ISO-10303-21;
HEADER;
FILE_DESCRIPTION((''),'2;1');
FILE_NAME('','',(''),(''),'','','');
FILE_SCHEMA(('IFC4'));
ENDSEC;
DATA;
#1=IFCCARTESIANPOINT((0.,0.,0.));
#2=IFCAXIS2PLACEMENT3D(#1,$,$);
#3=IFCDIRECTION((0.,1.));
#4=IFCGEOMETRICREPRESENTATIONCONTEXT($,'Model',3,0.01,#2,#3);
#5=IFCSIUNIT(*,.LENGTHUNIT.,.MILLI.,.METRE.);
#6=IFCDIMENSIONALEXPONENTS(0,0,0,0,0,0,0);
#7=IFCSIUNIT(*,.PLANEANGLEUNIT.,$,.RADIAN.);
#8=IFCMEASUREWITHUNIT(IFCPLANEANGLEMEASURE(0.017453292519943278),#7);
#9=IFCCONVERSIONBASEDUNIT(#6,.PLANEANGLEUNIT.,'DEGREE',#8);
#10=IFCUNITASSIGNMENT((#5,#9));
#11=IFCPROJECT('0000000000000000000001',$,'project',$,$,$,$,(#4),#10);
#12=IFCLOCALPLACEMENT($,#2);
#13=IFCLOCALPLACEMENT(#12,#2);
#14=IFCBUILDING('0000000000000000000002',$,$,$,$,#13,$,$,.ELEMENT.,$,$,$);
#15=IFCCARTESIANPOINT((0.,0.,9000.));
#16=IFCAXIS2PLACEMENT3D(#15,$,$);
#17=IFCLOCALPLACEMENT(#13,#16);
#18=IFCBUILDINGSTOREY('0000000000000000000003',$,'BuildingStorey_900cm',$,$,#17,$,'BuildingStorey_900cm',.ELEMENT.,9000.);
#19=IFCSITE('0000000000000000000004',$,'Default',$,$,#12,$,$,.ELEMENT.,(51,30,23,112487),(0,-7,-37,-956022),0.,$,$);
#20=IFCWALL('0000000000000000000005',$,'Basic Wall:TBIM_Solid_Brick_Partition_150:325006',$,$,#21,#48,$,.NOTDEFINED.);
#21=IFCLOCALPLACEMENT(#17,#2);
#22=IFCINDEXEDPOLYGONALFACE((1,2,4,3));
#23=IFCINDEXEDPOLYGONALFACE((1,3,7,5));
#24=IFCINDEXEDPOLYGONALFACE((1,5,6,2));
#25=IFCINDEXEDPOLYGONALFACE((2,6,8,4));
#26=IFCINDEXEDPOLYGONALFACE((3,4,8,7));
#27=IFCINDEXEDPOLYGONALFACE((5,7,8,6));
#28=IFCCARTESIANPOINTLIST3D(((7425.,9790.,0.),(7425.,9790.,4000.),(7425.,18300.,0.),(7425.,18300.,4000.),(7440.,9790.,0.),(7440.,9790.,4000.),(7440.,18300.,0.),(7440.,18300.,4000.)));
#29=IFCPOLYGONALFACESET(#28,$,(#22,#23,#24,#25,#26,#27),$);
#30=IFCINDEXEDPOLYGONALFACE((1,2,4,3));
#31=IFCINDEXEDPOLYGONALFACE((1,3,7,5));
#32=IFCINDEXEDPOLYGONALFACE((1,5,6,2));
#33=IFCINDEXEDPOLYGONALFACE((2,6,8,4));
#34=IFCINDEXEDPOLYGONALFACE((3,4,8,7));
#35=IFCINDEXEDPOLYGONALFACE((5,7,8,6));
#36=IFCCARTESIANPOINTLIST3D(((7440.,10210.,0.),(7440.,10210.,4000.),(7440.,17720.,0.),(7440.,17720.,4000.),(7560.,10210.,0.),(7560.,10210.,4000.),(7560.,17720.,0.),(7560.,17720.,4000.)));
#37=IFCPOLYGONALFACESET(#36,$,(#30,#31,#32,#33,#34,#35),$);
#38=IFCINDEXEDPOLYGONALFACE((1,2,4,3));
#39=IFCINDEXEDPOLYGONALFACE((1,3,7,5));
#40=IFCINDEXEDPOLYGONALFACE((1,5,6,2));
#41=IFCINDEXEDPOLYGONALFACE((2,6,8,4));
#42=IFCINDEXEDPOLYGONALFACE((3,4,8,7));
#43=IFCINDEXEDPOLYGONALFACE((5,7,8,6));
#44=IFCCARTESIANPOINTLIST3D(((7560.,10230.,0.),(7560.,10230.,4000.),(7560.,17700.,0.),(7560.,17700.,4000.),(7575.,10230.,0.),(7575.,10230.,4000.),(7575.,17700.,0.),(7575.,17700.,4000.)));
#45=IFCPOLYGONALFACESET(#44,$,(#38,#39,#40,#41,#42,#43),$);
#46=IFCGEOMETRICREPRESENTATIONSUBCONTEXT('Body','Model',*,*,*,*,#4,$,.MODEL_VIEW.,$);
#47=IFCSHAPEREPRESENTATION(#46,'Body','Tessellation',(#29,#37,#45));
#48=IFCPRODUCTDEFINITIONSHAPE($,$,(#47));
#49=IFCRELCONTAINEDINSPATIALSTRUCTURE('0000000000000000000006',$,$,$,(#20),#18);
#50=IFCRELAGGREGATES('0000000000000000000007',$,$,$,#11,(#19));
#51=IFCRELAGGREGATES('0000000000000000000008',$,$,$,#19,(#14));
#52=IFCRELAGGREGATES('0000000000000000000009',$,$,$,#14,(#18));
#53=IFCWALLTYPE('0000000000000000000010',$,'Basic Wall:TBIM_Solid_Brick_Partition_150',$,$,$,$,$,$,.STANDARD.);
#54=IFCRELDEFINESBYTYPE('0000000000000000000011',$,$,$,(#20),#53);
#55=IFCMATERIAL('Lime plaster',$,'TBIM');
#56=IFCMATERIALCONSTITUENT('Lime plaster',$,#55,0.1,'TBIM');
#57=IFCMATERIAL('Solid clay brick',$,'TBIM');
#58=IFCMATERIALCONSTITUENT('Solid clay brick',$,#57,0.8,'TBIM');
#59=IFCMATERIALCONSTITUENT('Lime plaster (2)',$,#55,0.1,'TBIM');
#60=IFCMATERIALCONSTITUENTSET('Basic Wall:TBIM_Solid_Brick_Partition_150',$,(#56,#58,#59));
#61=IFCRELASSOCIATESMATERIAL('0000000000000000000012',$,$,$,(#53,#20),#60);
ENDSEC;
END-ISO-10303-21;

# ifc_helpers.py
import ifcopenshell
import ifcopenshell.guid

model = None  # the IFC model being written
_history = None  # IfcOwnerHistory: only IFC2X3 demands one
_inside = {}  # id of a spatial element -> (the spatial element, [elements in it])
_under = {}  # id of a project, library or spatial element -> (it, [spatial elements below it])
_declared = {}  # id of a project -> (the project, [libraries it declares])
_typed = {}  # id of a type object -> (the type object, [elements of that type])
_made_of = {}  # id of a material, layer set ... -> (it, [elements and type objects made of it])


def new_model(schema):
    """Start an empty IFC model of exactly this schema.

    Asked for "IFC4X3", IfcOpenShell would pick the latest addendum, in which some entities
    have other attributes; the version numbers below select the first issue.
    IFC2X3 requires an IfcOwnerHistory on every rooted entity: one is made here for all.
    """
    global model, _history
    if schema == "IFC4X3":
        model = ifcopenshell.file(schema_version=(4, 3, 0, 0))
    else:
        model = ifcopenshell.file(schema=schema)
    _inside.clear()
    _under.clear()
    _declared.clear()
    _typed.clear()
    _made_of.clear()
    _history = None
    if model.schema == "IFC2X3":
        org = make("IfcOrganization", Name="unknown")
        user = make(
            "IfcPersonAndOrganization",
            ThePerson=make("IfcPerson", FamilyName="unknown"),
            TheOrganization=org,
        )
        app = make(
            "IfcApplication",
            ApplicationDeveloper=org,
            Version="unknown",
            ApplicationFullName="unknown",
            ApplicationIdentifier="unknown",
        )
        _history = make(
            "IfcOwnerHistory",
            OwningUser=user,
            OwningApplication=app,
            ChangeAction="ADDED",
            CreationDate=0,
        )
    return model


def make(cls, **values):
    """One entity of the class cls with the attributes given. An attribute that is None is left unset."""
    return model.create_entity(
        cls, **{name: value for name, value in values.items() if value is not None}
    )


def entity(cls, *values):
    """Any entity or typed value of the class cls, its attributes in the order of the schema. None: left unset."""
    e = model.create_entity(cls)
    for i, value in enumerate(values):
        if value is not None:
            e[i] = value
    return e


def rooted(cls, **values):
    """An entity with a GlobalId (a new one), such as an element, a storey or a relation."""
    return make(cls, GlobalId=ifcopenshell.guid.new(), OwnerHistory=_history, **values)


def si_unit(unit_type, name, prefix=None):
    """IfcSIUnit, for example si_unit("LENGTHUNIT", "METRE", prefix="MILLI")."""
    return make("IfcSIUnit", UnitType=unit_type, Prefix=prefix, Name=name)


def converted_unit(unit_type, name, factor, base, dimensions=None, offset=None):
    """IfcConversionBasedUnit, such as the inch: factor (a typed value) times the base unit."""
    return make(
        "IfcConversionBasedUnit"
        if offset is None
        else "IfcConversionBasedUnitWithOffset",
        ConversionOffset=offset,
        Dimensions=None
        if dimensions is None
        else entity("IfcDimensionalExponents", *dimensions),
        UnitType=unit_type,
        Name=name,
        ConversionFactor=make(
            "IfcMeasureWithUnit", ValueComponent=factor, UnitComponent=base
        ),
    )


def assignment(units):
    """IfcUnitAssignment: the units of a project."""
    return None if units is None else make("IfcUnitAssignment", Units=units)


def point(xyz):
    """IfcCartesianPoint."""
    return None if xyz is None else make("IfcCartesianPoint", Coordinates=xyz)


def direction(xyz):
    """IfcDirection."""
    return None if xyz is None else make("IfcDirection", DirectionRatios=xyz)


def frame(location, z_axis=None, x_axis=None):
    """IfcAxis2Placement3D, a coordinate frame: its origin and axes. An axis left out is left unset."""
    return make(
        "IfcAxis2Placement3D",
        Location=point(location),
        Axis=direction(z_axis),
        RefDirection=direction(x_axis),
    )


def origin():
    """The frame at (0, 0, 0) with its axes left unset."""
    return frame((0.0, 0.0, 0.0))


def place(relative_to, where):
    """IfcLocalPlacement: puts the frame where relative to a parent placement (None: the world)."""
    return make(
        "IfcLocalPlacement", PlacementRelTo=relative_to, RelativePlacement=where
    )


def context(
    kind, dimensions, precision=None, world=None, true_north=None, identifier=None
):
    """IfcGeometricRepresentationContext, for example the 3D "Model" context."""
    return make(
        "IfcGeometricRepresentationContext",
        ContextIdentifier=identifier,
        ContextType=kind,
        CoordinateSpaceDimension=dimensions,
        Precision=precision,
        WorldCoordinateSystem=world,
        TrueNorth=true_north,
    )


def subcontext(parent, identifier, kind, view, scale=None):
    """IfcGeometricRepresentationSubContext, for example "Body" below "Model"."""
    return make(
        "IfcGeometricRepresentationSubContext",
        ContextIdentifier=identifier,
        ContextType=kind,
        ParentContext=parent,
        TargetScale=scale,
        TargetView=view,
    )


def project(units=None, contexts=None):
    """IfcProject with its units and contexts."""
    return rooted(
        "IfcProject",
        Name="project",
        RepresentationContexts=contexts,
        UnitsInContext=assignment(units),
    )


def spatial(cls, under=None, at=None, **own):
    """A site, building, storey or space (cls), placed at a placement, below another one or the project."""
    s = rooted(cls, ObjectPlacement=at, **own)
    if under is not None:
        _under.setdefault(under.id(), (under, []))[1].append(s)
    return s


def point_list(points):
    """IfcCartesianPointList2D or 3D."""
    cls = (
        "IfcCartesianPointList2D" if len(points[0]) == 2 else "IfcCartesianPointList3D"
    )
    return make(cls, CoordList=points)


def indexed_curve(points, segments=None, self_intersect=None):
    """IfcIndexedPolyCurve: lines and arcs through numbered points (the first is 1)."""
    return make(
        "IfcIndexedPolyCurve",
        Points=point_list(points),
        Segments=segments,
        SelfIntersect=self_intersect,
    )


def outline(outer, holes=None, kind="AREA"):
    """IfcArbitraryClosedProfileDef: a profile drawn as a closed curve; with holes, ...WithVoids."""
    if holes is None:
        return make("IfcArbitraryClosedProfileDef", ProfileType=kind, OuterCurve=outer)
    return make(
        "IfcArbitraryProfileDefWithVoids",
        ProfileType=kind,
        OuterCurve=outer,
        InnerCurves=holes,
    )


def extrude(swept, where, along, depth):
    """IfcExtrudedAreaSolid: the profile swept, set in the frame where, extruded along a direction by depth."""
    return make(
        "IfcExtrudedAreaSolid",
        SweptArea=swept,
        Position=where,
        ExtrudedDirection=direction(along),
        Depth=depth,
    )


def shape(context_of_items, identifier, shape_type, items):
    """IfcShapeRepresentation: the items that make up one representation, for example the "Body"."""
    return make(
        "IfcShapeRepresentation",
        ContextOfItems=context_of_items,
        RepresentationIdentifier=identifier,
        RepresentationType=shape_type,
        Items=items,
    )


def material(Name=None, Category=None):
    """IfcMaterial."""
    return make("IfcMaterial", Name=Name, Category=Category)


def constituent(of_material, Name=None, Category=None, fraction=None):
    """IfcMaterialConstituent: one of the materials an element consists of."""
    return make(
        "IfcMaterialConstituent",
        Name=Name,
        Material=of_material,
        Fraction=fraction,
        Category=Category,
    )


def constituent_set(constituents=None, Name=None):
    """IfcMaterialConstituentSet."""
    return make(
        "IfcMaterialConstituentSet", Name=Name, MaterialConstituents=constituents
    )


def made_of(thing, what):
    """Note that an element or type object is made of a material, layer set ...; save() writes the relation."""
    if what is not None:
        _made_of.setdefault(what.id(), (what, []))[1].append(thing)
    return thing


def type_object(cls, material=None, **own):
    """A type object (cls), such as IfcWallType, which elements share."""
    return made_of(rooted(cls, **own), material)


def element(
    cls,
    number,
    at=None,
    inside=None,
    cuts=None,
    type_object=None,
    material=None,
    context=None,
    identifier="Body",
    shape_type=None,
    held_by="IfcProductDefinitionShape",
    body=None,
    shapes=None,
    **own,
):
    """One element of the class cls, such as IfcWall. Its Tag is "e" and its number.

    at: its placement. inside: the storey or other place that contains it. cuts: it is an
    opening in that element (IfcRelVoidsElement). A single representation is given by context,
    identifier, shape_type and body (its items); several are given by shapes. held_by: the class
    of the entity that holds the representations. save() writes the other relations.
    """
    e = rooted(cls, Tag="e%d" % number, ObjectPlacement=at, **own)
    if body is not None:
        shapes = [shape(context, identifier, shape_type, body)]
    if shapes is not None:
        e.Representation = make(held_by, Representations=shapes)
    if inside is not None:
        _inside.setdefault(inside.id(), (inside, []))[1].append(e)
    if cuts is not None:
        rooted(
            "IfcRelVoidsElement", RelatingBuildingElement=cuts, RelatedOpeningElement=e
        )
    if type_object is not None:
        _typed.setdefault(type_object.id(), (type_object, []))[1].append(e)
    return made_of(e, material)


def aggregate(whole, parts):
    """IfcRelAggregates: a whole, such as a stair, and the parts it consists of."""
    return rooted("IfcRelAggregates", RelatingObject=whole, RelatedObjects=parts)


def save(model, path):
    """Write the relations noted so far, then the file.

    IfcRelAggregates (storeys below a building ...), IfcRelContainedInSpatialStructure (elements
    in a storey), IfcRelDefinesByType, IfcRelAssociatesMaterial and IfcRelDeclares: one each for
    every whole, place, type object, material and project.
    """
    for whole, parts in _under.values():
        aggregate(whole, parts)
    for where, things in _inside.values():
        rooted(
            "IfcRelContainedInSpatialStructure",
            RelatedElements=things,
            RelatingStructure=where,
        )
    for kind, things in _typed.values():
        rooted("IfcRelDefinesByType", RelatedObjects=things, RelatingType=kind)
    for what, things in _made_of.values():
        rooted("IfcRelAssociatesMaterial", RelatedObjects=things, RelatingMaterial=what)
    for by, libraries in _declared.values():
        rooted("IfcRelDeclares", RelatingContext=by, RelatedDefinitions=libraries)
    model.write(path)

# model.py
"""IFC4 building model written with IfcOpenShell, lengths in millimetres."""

from ifc_helpers import new_model, entity, si_unit, converted_unit, direction, frame, origin, place, context, subcontext, project, spatial, indexed_curve, outline, extrude, material, constituent, constituent_set, type_object, element, save


model = new_model("IFC4")

# Units and contexts
model_context = context("Model", 3, precision=0.01, world=origin(), true_north=direction((0.0, 1.0)))
body_context = subcontext(model_context, "Body", "Model", "MODEL_VIEW")
ifc_project = project(units=[si_unit("LENGTHUNIT", "METRE", prefix="MILLI"), converted_unit("PLANEANGLEUNIT", "DEGREE", entity("IfcPlaneAngleMeasure", 0.017453292519943278), si_unit("PLANEANGLEUNIT", "RADIAN"), dimensions=[0, 0, 0, 0, 0, 0, 0])], contexts=[model_context])

# Site, building, storey
site_placement = place(None, origin())
site = spatial("IfcSite", under=ifc_project, at=site_placement, Name="Default", CompositionType="ELEMENT", RefLatitude=(51, 30, 23, 112487), RefLongitude=(0, -7, -37, -956022), RefElevation=0.0)
building_placement = place(site_placement, origin())
building = spatial("IfcBuilding", under=site, at=building_placement, CompositionType="ELEMENT")
storey_placement = place(building_placement, frame((0.0, 0.0, 9000.0)))
storey = spatial("IfcBuildingStorey", under=building, at=storey_placement, Name="BuildingStorey_900cm", LongName="BuildingStorey_900cm", CompositionType="ELEMENT", Elevation=9000.0)

# Shared definitions
ifc_material_1 = material(Name="Lime plaster", Category="TBIM")

# Shared definitions
ifc_material_2 = material(Name="Solid clay brick", Category="TBIM")

# Wall
ifc_constituent_1 = constituent(ifc_material_1, Name="Lime plaster", Category="TBIM", fraction=0.1)
ifc_constituent_2 = constituent(ifc_material_2, Name="Solid clay brick", Category="TBIM", fraction=0.8)
ifc_constituent_3 = constituent(ifc_material_1, Name="Lime plaster (2)", Category="TBIM", fraction=0.1)
ifc_constituent_set_1 = constituent_set(constituents=[ifc_constituent_1, ifc_constituent_2, ifc_constituent_3], Name="Basic Wall:TBIM_Solid_Brick_Partition_150")
wall_type_1 = type_object("IfcWallType", Name="Basic Wall:TBIM_Solid_Brick_Partition_150", PredefinedType="STANDARD", material=ifc_constituent_set_1)
wall_1_placement = place(storey_placement, frame((7500.0, 10230.0, 0.0), z_axis=(0.0, 0.0, 1.0), x_axis=(0.0, 1.0, 0.0)))
element("IfcWall", 1, at=wall_1_placement, inside=storey, type_object=wall_type_1, material=ifc_constituent_set_1, Name="Basic Wall:TBIM_Solid_Brick_Partition_150:325006", PredefinedType="NOTDEFINED", context=body_context, shape_type="SweptSolid", body=[
    extrude(outline(indexed_curve([(-7.5, -4255.0), (7.5, -4255.0), (7.5, 4255.0), (-7.5, 4255.0), (-7.5, -4255.0)], self_intersect=False)), frame((3815.0, 67.5, 0.0), z_axis=(0.0, 0.0, 1.0), x_axis=(0.0, -1.0, 0.0)), (0.0, 0.0, 1.0), 4000.0),
    extrude(outline(indexed_curve([(-3755.0, -60.0), (3755.0, -60.0), (3755.0, 60.0), (-3755.0, 60.0), (-3755.0, -60.0)], self_intersect=False)), frame((3735.0, 0.0, 0.0)), (0.0, 0.0, 1.0), 4000.0),
    extrude(outline(indexed_curve([(-7.5, -3735.0), (7.5, -3735.0), (7.5, 3735.0), (-7.5, 3735.0), (-7.5, -3735.0)], self_intersect=False)), frame((3735.0, -67.5, 0.0), z_axis=(0.0, 0.0, 1.0), x_axis=(0.0, 1.0, 0.0)), (0.0, 0.0, 1.0), 4000.0),
])

save(model, "model.ifc")
